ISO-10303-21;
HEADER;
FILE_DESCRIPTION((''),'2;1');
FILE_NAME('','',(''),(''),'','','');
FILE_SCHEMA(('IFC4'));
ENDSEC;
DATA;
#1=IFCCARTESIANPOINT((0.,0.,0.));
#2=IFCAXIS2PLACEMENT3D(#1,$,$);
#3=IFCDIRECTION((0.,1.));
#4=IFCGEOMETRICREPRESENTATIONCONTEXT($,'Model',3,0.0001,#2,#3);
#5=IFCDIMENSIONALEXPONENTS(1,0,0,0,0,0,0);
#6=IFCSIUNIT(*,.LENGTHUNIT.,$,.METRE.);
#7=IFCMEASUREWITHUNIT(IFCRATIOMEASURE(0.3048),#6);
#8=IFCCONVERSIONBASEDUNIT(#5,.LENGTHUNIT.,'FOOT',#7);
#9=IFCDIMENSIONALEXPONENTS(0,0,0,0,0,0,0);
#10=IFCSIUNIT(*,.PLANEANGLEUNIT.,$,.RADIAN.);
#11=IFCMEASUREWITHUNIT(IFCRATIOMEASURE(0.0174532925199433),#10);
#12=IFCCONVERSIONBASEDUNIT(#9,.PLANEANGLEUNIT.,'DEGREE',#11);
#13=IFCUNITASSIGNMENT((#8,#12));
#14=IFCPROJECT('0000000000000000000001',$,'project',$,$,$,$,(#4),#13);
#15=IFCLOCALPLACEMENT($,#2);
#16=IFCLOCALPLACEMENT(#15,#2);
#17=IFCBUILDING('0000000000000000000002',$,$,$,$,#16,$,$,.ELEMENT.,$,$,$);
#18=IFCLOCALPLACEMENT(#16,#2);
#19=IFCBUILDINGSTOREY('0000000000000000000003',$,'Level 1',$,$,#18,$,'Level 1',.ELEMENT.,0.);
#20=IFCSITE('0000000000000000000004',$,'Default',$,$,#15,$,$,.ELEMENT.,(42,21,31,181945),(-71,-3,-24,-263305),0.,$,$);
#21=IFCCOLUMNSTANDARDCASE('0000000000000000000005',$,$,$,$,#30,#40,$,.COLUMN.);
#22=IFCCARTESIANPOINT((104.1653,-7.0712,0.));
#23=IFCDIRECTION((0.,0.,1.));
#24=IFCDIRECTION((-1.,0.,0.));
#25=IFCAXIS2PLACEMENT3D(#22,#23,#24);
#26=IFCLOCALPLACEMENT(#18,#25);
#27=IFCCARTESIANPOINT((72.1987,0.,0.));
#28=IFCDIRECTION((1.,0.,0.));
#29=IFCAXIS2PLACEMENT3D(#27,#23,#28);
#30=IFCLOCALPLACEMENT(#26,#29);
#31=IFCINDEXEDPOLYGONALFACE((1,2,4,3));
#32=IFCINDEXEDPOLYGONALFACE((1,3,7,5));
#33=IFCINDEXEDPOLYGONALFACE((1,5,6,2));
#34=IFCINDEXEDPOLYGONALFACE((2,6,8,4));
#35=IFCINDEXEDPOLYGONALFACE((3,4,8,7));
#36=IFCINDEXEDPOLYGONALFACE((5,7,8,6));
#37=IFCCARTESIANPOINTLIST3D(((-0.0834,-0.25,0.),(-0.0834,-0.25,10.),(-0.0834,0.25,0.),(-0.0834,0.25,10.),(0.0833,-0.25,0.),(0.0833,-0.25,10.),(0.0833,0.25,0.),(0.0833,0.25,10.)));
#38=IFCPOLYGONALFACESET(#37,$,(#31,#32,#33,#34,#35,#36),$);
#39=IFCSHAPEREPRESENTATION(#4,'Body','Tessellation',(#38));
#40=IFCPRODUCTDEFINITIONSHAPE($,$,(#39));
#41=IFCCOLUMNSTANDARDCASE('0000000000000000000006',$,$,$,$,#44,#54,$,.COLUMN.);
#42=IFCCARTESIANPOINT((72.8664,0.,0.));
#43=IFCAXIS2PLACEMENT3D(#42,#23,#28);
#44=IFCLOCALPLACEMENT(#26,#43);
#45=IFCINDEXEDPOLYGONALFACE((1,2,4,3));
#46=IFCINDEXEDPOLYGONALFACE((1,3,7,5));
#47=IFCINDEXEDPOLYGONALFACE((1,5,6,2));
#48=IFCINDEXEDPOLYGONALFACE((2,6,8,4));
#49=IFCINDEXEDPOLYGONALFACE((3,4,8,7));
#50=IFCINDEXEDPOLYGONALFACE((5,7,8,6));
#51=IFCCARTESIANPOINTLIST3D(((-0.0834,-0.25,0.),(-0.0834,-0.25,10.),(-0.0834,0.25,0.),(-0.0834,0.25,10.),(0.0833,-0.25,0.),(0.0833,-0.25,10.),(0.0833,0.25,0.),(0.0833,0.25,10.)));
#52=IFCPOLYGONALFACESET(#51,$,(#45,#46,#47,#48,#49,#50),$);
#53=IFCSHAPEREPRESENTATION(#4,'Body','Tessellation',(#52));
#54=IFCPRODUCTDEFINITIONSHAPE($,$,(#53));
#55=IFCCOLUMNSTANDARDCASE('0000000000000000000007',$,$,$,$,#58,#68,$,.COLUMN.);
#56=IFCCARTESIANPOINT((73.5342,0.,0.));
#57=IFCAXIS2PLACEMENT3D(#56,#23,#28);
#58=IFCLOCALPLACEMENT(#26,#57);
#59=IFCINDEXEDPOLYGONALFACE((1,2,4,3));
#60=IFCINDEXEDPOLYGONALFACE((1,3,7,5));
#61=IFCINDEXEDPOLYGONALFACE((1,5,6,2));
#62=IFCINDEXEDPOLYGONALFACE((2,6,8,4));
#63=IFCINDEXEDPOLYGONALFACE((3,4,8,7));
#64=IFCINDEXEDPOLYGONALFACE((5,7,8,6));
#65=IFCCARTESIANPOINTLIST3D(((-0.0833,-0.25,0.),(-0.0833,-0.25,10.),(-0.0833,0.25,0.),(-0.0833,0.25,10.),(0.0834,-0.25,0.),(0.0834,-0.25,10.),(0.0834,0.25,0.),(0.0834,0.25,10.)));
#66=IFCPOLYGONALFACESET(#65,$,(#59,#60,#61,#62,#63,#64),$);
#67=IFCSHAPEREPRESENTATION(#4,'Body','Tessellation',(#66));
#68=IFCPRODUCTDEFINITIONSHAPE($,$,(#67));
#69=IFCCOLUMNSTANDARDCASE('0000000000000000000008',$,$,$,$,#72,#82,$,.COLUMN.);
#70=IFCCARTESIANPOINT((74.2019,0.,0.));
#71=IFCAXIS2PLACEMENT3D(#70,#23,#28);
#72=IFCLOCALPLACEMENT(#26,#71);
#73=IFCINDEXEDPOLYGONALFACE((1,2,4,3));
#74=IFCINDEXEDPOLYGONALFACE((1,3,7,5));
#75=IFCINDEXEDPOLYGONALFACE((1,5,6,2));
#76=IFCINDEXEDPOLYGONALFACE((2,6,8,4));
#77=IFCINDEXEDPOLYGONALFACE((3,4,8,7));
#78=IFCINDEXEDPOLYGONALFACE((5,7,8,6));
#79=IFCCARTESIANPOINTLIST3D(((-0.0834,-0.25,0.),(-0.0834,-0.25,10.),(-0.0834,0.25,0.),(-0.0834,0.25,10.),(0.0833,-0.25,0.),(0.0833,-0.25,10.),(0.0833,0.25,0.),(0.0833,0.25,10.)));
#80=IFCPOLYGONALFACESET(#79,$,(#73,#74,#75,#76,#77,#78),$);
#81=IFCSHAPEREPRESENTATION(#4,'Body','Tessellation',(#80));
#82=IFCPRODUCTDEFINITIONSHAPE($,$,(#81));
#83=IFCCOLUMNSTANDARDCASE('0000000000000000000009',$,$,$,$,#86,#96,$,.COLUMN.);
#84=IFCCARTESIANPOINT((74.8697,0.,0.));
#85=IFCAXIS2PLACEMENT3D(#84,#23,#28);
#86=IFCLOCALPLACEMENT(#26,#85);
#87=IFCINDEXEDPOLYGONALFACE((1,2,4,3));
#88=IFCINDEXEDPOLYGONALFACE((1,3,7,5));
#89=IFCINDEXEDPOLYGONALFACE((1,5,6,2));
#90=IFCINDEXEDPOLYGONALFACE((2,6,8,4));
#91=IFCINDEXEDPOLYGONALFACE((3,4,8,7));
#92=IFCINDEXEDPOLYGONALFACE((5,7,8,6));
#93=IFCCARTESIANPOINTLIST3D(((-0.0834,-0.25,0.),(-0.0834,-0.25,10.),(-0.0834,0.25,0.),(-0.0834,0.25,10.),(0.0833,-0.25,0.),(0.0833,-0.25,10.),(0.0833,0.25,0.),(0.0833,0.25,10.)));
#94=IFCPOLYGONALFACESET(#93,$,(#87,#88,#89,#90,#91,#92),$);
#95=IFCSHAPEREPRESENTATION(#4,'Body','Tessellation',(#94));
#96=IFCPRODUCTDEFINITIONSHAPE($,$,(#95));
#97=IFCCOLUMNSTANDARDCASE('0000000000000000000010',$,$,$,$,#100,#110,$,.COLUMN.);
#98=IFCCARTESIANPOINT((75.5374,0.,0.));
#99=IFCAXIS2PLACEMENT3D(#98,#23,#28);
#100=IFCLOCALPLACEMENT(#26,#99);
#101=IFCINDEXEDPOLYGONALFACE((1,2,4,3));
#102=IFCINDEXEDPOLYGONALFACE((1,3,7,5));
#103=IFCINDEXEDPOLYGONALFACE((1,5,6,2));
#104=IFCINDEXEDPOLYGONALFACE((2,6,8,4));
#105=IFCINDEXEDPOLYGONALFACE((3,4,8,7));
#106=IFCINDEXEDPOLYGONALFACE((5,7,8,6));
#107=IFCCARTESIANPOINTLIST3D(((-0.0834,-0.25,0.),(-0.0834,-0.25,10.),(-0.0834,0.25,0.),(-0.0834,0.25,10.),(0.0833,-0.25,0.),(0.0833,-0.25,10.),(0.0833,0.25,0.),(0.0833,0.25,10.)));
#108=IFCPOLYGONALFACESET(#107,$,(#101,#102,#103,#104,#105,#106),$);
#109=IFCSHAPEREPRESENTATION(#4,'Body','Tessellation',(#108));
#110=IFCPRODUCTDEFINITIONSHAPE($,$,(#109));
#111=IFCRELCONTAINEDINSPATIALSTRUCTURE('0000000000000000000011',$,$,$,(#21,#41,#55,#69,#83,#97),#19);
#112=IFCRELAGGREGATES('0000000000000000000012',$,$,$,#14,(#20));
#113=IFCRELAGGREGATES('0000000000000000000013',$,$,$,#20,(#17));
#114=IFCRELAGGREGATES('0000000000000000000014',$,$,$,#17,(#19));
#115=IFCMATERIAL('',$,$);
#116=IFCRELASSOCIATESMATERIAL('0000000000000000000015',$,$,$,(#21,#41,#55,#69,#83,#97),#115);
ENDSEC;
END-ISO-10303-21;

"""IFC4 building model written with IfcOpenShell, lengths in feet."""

from ifc_helpers import new_model, entity, si_unit, converted_unit, direction, frame, origin, place, context, project, spatial, rectangle, extrude, material, element, save


model = new_model("IFC4")

# Units and contexts
model_context = context("Model", 3, precision=0.0001, world=origin(), true_north=direction((0.0, 1.0)))
ifc_project = project(units=[converted_unit("LENGTHUNIT", "FOOT", entity("IfcRatioMeasure", 0.3048), si_unit("LENGTHUNIT", "METRE"), dimensions=[1, 0, 0, 0, 0, 0, 0]), converted_unit("PLANEANGLEUNIT", "DEGREE", entity("IfcRatioMeasure", 0.0174532925199433), si_unit("PLANEANGLEUNIT", "RADIAN"), dimensions=[0, 0, 0, 0, 0, 0, 0])], contexts=[model_context])

# Site, building, storey
site_placement = place(None, origin())
site = spatial("IfcSite", under=ifc_project, at=site_placement, Name="Default", CompositionType="ELEMENT", RefLatitude=(42, 21, 31, 181945), RefLongitude=(-71, -3, -24, -263305), RefElevation=0.0)
building_placement = place(site_placement, origin())
building = spatial("IfcBuilding", under=site, at=building_placement, CompositionType="ELEMENT")
storey_placement = place(building_placement, origin())
storey = spatial("IfcBuildingStorey", under=building, at=storey_placement, Name="Level 1", LongName="Level 1", CompositionType="ELEMENT", Elevation=0.0)

# Columns
ifc_material = material(Name="")
placement = place(storey_placement, frame((104.1653, -7.0712, 0.0), z_axis=(0.0, 0.0, 1.0), x_axis=(-1.0, 0.0, 0.0)))
for number, where, z_axis, x_axis in (
    (1, (72.1987, 0.0, 0.0), (0.0, 0.0, 1.0), (1.0, 0.0, 0.0)),
    (2, (72.8664, 0.0, 0.0), (0.0, 0.0, 1.0), (1.0, 0.0, 0.0)),
    (3, (73.5342, 0.0, 0.0), (0.0, 0.0, 1.0), (1.0, 0.0, 0.0)),
    (4, (74.2019, 0.0, 0.0), (0.0, 0.0, 1.0), (1.0, 0.0, 0.0)),
    (5, (74.8697, 0.0, 0.0), (0.0, 0.0, 1.0), (1.0, 0.0, 0.0)),
    (6, (75.5374, 0.0, 0.0), (0.0, 0.0, 1.0), (1.0, 0.0, 0.0)),
):
    element("IfcColumnStandardCase", number, at=place(placement, frame(where, z_axis=z_axis, x_axis=x_axis)), inside=storey, material=ifc_material, PredefinedType="COLUMN", context=model_context, shape_type="SweptSolid", body=[
        extrude(rectangle(XDim=0.1667, YDim=0.5), origin(), (0.0, 0.0, 1.0), 10.0),
    ])

save(model, "model.ifc")
